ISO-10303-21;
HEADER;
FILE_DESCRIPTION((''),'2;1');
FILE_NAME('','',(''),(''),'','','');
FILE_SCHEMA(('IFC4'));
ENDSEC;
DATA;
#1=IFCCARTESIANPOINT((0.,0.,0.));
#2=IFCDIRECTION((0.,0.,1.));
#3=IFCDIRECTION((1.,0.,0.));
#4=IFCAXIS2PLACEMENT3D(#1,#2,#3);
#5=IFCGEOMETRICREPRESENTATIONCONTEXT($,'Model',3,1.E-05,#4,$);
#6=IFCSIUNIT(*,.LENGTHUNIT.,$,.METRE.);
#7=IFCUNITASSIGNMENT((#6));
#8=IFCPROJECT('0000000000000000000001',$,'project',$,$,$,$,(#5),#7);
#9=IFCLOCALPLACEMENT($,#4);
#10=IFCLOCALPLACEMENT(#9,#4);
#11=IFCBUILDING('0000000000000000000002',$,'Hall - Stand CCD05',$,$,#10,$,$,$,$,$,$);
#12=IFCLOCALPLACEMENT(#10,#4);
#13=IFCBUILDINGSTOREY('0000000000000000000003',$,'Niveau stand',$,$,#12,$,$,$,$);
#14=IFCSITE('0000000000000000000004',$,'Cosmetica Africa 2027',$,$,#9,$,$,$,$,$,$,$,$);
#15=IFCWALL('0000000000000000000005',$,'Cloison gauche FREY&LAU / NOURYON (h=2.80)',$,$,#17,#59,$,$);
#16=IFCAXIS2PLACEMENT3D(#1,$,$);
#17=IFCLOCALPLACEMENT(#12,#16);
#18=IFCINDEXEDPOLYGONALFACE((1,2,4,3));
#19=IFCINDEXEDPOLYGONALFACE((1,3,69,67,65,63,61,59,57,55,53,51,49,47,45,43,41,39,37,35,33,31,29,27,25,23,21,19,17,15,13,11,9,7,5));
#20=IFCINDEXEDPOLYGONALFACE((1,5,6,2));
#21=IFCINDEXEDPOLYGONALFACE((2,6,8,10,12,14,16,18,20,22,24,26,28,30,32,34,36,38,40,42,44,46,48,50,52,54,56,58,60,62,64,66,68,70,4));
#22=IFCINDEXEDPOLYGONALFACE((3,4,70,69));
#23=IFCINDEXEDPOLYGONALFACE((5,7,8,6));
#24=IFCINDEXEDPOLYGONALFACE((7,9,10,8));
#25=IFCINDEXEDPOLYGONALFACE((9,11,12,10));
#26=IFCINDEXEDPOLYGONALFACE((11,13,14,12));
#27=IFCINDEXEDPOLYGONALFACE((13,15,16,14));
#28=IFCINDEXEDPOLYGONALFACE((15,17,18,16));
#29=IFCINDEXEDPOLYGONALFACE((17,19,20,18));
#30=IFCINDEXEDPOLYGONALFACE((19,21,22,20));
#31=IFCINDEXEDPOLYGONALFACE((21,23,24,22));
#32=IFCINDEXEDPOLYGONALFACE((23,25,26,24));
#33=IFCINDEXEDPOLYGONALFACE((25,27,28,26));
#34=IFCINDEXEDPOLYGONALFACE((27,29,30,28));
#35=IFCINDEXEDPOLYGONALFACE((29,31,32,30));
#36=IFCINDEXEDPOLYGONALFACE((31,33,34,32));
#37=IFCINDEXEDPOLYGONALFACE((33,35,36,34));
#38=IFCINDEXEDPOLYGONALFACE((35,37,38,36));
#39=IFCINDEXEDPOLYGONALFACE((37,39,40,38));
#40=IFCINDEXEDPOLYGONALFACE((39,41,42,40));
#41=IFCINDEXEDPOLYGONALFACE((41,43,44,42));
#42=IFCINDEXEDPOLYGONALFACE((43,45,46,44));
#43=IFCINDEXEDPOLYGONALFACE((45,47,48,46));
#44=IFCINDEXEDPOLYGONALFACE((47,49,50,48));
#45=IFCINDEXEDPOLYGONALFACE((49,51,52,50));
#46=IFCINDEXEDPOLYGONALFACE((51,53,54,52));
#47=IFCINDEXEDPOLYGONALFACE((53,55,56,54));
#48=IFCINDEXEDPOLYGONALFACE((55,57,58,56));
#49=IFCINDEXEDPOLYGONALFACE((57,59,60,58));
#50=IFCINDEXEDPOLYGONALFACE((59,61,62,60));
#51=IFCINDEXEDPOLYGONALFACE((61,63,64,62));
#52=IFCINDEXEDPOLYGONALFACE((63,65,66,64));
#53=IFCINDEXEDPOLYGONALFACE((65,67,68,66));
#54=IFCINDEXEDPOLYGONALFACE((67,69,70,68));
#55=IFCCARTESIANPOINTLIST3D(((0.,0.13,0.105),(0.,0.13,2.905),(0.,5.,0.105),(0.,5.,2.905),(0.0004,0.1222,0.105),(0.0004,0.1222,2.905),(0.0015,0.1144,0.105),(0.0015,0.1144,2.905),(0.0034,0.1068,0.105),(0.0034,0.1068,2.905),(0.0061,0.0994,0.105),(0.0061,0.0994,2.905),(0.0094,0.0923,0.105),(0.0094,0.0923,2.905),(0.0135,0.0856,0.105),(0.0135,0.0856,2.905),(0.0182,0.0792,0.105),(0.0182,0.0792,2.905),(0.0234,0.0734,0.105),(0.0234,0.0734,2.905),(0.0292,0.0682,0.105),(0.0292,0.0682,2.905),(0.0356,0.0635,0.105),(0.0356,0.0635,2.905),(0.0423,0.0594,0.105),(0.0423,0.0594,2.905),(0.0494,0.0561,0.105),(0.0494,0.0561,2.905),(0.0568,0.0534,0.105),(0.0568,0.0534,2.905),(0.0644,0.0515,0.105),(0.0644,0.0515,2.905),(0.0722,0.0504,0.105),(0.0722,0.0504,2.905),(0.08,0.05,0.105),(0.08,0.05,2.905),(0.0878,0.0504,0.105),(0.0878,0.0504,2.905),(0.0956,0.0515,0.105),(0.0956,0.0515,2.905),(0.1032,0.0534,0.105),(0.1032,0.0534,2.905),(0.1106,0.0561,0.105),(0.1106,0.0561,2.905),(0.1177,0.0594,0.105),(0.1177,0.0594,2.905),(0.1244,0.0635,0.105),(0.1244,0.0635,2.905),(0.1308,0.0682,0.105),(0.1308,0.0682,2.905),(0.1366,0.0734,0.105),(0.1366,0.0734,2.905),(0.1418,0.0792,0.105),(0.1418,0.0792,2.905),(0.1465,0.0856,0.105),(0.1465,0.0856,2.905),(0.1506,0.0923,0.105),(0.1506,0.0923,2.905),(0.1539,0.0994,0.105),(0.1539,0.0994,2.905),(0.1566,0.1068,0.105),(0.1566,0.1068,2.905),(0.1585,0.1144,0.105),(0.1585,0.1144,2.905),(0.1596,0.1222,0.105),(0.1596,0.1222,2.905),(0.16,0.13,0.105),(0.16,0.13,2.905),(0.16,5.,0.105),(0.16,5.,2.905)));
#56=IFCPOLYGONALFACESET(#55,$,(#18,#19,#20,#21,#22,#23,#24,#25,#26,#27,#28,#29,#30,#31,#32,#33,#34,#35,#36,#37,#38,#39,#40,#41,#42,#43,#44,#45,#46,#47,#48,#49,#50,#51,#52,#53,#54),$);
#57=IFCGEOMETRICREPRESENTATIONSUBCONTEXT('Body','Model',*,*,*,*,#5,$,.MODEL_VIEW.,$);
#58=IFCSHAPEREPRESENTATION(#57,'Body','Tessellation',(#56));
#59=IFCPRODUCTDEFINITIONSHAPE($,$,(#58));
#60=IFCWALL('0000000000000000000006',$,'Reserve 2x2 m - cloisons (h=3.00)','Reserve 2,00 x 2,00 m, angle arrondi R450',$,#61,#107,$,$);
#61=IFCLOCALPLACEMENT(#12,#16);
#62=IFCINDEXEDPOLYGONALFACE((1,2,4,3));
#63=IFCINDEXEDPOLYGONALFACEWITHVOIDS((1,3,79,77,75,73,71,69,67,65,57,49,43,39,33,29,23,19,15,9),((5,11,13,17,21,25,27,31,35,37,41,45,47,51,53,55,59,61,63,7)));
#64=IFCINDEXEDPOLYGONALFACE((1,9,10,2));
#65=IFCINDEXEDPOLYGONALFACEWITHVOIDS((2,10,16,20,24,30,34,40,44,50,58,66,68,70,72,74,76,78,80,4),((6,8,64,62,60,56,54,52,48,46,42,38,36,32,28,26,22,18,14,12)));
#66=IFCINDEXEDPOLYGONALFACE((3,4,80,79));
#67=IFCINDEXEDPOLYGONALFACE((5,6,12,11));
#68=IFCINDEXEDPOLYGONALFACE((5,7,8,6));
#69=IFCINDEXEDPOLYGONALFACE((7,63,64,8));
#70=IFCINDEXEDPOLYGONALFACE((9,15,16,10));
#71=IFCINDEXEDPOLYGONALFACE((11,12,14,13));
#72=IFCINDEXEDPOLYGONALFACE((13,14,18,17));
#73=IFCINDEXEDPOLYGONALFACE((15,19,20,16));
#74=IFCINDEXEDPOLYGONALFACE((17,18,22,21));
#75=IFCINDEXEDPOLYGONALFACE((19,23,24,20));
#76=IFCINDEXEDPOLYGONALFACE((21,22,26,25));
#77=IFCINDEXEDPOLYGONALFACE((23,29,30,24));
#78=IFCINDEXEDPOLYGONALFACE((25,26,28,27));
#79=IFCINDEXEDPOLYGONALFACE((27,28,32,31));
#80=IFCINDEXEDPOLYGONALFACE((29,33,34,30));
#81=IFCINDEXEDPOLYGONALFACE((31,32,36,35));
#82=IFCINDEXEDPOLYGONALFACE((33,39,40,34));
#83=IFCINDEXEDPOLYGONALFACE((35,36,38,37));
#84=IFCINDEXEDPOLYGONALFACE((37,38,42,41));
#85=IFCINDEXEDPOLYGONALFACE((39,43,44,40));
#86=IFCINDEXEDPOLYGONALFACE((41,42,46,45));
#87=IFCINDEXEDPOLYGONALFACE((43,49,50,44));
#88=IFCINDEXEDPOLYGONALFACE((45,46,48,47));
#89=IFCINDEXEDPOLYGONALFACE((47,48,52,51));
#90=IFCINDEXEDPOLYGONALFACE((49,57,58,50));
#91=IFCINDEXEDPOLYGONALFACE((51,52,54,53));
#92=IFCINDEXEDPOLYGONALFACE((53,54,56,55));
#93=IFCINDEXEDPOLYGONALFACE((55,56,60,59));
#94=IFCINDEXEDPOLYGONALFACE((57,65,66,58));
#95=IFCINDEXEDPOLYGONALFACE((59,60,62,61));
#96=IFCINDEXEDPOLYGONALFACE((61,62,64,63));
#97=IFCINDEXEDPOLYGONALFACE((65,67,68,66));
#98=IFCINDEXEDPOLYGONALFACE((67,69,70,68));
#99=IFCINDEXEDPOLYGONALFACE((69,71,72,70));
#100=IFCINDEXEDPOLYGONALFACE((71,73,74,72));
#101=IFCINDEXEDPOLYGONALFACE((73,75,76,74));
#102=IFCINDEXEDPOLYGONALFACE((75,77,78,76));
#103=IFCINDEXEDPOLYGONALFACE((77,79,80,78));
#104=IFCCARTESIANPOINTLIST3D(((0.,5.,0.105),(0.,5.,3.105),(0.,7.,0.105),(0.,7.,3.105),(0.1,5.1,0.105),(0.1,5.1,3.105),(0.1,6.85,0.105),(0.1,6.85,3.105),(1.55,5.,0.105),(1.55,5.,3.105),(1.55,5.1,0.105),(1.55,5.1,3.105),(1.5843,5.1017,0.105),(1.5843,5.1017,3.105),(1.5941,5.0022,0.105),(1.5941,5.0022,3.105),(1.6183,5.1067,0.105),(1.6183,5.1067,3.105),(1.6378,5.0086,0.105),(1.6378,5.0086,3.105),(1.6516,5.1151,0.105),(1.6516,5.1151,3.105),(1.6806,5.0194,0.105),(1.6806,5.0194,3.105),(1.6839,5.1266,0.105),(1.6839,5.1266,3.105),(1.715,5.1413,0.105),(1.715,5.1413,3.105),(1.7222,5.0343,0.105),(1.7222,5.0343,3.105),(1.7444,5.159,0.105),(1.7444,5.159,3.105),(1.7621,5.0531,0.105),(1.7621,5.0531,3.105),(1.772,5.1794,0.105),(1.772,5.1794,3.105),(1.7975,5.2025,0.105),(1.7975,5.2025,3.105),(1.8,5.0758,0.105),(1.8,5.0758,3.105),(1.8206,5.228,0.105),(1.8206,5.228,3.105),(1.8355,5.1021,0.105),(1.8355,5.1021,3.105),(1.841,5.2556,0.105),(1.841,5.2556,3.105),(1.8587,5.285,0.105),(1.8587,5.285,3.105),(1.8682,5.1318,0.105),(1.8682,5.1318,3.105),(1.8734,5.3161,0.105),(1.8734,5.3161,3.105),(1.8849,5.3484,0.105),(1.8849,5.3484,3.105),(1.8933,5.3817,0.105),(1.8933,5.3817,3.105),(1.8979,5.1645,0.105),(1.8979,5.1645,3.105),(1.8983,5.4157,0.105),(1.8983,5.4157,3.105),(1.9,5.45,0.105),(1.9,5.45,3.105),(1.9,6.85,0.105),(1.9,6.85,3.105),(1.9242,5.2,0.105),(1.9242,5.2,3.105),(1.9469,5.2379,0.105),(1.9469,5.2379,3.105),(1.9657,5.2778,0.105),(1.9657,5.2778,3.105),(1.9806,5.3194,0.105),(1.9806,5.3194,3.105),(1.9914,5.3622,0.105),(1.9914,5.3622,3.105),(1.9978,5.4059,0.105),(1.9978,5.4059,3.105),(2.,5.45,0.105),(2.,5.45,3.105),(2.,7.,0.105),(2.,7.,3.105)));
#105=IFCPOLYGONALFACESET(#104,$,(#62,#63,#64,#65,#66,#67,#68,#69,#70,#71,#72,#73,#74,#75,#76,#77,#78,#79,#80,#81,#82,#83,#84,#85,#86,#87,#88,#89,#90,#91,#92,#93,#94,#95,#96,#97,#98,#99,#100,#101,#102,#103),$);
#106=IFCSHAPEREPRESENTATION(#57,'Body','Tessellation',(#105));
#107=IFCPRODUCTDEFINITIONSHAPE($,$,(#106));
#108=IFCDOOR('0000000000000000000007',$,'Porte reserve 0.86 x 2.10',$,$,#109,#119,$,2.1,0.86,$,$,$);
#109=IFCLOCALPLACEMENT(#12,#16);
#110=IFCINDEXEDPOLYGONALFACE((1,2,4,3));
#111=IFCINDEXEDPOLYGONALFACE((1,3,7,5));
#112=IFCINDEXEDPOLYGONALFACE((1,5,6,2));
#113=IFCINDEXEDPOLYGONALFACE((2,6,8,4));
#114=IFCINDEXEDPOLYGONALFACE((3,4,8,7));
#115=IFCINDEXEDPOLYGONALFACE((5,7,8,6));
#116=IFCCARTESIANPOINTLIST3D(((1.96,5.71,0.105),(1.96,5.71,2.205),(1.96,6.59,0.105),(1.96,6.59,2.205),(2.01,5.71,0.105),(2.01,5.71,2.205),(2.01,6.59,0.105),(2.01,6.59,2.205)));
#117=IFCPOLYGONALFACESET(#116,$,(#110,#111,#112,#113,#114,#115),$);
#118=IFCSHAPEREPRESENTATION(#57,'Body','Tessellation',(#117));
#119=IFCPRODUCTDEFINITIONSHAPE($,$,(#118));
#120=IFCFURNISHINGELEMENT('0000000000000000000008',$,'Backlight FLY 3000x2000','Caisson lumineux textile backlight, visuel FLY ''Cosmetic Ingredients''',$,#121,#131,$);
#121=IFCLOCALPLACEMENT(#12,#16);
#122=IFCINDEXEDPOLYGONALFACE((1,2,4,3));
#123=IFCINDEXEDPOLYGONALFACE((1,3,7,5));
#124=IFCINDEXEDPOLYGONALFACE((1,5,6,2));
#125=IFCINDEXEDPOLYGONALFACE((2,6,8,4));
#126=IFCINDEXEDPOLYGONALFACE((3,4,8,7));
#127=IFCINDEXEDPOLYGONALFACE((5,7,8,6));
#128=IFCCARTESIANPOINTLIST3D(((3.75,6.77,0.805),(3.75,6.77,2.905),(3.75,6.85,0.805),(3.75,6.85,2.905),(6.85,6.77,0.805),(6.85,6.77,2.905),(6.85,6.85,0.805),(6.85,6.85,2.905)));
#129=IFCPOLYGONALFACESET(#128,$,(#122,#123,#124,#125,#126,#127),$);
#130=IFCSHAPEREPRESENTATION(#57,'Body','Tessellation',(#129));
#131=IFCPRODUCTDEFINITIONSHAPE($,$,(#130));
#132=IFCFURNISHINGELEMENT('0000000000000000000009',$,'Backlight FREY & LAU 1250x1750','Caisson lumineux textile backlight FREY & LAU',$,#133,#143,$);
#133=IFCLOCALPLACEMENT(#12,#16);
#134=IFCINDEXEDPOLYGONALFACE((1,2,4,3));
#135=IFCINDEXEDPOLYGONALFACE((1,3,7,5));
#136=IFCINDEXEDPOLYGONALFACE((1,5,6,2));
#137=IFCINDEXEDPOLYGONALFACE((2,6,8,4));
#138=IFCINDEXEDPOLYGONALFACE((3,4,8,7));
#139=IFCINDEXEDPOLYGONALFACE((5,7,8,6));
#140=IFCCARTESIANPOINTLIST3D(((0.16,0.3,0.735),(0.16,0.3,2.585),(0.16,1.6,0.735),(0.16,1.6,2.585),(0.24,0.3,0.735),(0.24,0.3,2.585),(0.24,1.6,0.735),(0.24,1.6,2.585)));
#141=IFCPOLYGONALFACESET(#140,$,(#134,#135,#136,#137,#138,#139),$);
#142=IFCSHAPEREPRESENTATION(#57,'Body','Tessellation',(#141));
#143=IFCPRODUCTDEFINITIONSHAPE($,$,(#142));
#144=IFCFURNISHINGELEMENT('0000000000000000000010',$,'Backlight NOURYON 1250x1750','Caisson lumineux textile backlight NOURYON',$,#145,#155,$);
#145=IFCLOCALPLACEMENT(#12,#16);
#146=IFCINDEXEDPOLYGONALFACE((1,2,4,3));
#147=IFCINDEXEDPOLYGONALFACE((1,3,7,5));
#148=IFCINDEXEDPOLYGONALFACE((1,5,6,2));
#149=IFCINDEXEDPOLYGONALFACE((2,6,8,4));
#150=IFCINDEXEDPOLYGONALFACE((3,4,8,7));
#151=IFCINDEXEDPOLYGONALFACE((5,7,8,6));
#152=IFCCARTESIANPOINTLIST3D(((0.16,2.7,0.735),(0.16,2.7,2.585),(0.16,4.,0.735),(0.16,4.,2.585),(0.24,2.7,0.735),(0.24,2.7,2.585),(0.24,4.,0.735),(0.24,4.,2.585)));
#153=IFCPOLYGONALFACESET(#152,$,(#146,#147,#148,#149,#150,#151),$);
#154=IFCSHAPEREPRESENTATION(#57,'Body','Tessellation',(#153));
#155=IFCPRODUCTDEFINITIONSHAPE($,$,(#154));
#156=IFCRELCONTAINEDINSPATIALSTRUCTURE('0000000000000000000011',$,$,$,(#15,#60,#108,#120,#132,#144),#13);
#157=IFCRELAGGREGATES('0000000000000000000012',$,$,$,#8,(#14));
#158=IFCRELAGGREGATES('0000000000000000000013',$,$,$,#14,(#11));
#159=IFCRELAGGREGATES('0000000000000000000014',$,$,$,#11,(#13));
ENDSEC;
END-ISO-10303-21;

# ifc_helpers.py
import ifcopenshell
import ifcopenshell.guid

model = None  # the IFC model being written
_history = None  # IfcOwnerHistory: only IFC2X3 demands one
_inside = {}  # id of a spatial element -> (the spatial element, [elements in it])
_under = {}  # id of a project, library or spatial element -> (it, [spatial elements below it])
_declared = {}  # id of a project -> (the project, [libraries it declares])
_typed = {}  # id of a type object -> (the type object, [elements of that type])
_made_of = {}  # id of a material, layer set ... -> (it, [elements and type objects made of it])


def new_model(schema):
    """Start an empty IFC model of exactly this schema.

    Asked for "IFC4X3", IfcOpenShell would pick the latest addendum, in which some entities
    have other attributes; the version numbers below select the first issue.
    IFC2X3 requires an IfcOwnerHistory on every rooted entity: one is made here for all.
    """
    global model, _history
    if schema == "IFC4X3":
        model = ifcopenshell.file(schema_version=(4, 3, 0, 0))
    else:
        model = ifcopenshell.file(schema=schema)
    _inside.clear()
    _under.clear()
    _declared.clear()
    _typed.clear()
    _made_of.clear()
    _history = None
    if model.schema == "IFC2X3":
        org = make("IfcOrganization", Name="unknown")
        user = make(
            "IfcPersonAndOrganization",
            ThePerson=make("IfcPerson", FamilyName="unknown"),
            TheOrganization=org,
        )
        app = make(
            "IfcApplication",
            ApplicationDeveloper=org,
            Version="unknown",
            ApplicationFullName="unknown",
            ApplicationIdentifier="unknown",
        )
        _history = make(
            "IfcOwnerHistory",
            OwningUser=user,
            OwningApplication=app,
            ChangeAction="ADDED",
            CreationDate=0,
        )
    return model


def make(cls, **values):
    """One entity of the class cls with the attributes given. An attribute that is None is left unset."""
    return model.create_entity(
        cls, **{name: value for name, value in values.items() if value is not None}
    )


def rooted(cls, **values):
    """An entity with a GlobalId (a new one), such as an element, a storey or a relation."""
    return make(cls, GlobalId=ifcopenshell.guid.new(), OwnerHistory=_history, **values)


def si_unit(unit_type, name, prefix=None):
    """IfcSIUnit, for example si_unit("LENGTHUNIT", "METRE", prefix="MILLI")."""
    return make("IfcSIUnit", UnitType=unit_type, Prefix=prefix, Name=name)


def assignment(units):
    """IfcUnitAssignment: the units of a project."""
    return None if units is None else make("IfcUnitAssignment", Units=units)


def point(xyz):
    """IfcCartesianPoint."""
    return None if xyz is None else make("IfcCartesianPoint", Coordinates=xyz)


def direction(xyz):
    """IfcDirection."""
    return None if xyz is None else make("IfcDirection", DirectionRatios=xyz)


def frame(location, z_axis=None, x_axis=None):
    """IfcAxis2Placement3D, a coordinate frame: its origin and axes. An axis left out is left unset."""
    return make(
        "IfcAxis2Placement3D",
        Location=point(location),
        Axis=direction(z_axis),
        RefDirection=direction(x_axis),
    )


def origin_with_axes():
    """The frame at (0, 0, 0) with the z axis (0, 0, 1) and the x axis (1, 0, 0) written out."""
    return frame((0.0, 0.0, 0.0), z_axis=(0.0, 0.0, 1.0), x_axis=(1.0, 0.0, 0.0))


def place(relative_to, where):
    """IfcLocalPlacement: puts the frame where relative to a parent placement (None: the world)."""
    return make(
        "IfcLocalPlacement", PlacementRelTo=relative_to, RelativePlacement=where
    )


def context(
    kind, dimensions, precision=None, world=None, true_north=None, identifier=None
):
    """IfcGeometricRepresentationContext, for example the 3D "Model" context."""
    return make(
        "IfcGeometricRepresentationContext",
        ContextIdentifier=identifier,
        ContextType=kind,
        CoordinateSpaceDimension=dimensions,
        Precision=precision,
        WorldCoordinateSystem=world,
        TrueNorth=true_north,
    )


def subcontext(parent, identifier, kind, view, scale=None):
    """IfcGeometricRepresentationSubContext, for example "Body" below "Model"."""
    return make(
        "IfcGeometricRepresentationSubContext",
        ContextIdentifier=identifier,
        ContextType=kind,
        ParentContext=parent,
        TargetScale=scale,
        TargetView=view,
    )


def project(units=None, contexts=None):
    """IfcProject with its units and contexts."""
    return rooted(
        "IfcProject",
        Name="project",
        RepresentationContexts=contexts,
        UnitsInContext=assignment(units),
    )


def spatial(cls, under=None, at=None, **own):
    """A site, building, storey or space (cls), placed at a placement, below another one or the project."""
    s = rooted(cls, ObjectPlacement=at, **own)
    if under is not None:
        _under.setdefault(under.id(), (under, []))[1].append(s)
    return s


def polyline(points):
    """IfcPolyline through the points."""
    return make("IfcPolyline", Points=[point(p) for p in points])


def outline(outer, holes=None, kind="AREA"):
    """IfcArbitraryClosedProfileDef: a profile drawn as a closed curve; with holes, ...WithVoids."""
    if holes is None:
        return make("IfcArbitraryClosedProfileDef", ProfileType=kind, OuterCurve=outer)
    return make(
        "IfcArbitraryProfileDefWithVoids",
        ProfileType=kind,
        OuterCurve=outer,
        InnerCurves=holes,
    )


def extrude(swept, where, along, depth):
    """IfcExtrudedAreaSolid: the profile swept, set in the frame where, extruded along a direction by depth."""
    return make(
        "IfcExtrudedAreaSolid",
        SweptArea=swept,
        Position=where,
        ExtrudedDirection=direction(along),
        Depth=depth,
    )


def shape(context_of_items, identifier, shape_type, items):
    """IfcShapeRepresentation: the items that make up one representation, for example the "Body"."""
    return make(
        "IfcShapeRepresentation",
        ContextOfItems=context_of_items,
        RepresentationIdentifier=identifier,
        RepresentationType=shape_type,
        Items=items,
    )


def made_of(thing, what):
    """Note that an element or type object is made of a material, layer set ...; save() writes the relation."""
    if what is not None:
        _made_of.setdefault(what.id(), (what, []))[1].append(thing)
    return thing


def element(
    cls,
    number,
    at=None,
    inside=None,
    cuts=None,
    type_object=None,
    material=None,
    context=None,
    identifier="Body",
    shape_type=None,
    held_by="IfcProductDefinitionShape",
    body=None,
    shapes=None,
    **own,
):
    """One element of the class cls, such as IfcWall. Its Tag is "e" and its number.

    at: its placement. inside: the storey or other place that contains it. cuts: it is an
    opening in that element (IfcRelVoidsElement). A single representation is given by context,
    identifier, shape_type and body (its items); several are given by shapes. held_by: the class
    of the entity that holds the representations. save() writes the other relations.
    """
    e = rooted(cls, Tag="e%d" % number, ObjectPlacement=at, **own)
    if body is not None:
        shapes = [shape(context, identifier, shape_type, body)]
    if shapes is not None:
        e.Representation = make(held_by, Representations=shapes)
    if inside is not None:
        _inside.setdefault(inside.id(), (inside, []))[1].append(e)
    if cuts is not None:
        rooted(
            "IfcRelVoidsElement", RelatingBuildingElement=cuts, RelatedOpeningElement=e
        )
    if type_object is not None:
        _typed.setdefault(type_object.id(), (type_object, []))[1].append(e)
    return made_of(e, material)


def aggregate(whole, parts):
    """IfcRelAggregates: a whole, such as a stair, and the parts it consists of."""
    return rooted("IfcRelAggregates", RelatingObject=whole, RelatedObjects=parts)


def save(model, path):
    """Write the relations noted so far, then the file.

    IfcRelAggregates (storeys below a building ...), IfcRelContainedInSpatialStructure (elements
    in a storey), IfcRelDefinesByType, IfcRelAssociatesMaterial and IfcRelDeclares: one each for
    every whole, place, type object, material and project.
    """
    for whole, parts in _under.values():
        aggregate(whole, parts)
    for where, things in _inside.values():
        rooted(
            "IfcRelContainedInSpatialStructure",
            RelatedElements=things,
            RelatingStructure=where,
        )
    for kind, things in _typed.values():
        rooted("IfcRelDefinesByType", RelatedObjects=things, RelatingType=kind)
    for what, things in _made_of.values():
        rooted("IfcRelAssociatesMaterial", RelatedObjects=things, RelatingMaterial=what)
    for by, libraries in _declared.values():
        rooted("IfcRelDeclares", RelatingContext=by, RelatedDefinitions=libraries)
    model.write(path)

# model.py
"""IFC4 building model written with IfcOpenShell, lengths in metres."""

from ifc_helpers import new_model, si_unit, frame, origin_with_axes, place, context, subcontext, project, spatial, polyline, outline, extrude, element, save


model = new_model("IFC4")

# Units and contexts
model_context = context("Model", 3, precision=1e-05, world=origin_with_axes())
body_context = subcontext(model_context, "Body", "Model", "MODEL_VIEW")
ifc_project = project(units=[si_unit("LENGTHUNIT", "METRE")], contexts=[model_context])

# Site, building, storey
site_placement = place(None, origin_with_axes())
site = spatial("IfcSite", under=ifc_project, at=site_placement, Name="Cosmetica Africa 2027")
building_placement = place(site_placement, origin_with_axes())
building = spatial("IfcBuilding", under=site, at=building_placement, Name="Hall - Stand CCD05")
storey_placement = place(building_placement, origin_with_axes())
storey = spatial("IfcBuildingStorey", under=building, at=storey_placement, Name="Niveau stand")

# Walls
wall_1_placement = place(storey_placement, origin_with_axes())
element("IfcWall", 1, at=wall_1_placement, inside=storey, Name="Cloison gauche FREY&LAU / NOURYON (h=2.80)", context=body_context, shape_type="SweptSolid", body=[
    extrude(outline(polyline([(0.0, 0.13), (0.0004, 0.1222), (0.0015, 0.1144), (0.0034, 0.1068), (0.0061, 0.0994), (0.0094, 0.0923), (0.0135, 0.0856), (0.0182, 0.0792), (0.0234, 0.0734), (0.0292, 0.0682), (0.0356, 0.0635), (0.0423, 0.0594), (0.0494, 0.0561), (0.0568, 0.0534), (0.0644, 0.0515), (0.0722, 0.0504), (0.08, 0.05), (0.08, 0.05), (0.0878, 0.0504), (0.0956, 0.0515), (0.1032, 0.0534), (0.1106, 0.0561), (0.1177, 0.0594), (0.1244, 0.0635), (0.1308, 0.0682), (0.1366, 0.0734), (0.1418, 0.0792), (0.1465, 0.0856), (0.1506, 0.0923), (0.1539, 0.0994), (0.1566, 0.1068), (0.1585, 0.1144), (0.1596, 0.1222), (0.16, 0.13), (0.16, 5.0), (0.0, 5.0), (0.0, 0.13)])), frame((0.0, 0.0, 0.105)), (0.0, 0.0, 1.0), 2.8),
])
wall_2_placement = place(storey_placement, origin_with_axes())
element("IfcWall", 2, at=wall_2_placement, inside=storey, Name="Reserve 2x2 m - cloisons (h=3.00)", Description="Reserve 2,00 x 2,00 m, angle arrondi R450", context=body_context, shape_type="SweptSolid", body=[
    extrude(outline(polyline([(0.0, 5.0), (1.55, 5.0), (1.5941, 5.0022), (1.6378, 5.0086), (1.6806, 5.0194), (1.7222, 5.0343), (1.7621, 5.0531), (1.8, 5.0758), (1.8355, 5.1021), (1.8682, 5.1318), (1.8979, 5.1645), (1.9242, 5.2), (1.9469, 5.2379), (1.9657, 5.2778), (1.9806, 5.3194), (1.9914, 5.3622), (1.9978, 5.4059), (2.0, 5.45), (2.0, 7.0), (0.0, 7.0), (0.0, 5.0)]), holes=[polyline([(0.1, 5.1), (1.55, 5.1), (1.5843, 5.1017), (1.6183, 5.1067), (1.6516, 5.1151), (1.6839, 5.1266), (1.715, 5.1413), (1.7444, 5.159), (1.772, 5.1794), (1.7975, 5.2025), (1.8206, 5.228), (1.841, 5.2556), (1.8587, 5.285), (1.8734, 5.3161), (1.8849, 5.3484), (1.8933, 5.3817), (1.8983, 5.4157), (1.9, 5.45), (1.9, 6.85), (0.1, 6.85), (0.1, 5.1)])]), frame((0.0, 0.0, 0.105)), (0.0, 0.0, 1.0), 3.0),
])

# Door
door_placement = place(storey_placement, origin_with_axes())
element("IfcDoor", 3, at=door_placement, inside=storey, Name="Porte reserve 0.86 x 2.10", OverallHeight=2.1, OverallWidth=0.86, context=body_context, shape_type="SweptSolid", body=[
    extrude(outline(polyline([(1.96, 5.71), (2.01, 5.71), (2.01, 6.59), (1.96, 6.59), (1.96, 5.71)])), frame((0.0, 0.0, 0.105)), (0.0, 0.0, 1.0), 2.1),
])

# Furnishing elements
furnishing_1_placement = place(storey_placement, origin_with_axes())
element("IfcFurnishingElement", 4, at=furnishing_1_placement, inside=storey, Name="Backlight FLY 3000x2000", Description="Caisson lumineux textile backlight, visuel FLY 'Cosmetic Ingredients'", context=body_context, shape_type="SweptSolid", body=[
    extrude(outline(polyline([(3.75, 6.77), (6.85, 6.77), (6.85, 6.85), (3.75, 6.85), (3.75, 6.77)])), frame((0.0, 0.0, 0.805)), (0.0, 0.0, 1.0), 2.1),
])
furnishing_2_placement = place(storey_placement, origin_with_axes())
element("IfcFurnishingElement", 5, at=furnishing_2_placement, inside=storey, Name="Backlight FREY & LAU 1250x1750", Description="Caisson lumineux textile backlight FREY & LAU", context=body_context, shape_type="SweptSolid", body=[
    extrude(outline(polyline([(0.16, 0.3), (0.24, 0.3), (0.24, 1.6), (0.16, 1.6), (0.16, 0.3)])), frame((0.0, 0.0, 0.735)), (0.0, 0.0, 1.0), 1.85),
])
furnishing_3_placement = place(storey_placement, origin_with_axes())
element("IfcFurnishingElement", 6, at=furnishing_3_placement, inside=storey, Name="Backlight NOURYON 1250x1750", Description="Caisson lumineux textile backlight NOURYON", context=body_context, shape_type="SweptSolid", body=[
    extrude(outline(polyline([(0.16, 2.7), (0.24, 2.7), (0.24, 4.0), (0.16, 4.0), (0.16, 2.7)])), frame((0.0, 0.0, 0.735)), (0.0, 0.0, 1.0), 1.85),
])

save(model, "model.ifc")
